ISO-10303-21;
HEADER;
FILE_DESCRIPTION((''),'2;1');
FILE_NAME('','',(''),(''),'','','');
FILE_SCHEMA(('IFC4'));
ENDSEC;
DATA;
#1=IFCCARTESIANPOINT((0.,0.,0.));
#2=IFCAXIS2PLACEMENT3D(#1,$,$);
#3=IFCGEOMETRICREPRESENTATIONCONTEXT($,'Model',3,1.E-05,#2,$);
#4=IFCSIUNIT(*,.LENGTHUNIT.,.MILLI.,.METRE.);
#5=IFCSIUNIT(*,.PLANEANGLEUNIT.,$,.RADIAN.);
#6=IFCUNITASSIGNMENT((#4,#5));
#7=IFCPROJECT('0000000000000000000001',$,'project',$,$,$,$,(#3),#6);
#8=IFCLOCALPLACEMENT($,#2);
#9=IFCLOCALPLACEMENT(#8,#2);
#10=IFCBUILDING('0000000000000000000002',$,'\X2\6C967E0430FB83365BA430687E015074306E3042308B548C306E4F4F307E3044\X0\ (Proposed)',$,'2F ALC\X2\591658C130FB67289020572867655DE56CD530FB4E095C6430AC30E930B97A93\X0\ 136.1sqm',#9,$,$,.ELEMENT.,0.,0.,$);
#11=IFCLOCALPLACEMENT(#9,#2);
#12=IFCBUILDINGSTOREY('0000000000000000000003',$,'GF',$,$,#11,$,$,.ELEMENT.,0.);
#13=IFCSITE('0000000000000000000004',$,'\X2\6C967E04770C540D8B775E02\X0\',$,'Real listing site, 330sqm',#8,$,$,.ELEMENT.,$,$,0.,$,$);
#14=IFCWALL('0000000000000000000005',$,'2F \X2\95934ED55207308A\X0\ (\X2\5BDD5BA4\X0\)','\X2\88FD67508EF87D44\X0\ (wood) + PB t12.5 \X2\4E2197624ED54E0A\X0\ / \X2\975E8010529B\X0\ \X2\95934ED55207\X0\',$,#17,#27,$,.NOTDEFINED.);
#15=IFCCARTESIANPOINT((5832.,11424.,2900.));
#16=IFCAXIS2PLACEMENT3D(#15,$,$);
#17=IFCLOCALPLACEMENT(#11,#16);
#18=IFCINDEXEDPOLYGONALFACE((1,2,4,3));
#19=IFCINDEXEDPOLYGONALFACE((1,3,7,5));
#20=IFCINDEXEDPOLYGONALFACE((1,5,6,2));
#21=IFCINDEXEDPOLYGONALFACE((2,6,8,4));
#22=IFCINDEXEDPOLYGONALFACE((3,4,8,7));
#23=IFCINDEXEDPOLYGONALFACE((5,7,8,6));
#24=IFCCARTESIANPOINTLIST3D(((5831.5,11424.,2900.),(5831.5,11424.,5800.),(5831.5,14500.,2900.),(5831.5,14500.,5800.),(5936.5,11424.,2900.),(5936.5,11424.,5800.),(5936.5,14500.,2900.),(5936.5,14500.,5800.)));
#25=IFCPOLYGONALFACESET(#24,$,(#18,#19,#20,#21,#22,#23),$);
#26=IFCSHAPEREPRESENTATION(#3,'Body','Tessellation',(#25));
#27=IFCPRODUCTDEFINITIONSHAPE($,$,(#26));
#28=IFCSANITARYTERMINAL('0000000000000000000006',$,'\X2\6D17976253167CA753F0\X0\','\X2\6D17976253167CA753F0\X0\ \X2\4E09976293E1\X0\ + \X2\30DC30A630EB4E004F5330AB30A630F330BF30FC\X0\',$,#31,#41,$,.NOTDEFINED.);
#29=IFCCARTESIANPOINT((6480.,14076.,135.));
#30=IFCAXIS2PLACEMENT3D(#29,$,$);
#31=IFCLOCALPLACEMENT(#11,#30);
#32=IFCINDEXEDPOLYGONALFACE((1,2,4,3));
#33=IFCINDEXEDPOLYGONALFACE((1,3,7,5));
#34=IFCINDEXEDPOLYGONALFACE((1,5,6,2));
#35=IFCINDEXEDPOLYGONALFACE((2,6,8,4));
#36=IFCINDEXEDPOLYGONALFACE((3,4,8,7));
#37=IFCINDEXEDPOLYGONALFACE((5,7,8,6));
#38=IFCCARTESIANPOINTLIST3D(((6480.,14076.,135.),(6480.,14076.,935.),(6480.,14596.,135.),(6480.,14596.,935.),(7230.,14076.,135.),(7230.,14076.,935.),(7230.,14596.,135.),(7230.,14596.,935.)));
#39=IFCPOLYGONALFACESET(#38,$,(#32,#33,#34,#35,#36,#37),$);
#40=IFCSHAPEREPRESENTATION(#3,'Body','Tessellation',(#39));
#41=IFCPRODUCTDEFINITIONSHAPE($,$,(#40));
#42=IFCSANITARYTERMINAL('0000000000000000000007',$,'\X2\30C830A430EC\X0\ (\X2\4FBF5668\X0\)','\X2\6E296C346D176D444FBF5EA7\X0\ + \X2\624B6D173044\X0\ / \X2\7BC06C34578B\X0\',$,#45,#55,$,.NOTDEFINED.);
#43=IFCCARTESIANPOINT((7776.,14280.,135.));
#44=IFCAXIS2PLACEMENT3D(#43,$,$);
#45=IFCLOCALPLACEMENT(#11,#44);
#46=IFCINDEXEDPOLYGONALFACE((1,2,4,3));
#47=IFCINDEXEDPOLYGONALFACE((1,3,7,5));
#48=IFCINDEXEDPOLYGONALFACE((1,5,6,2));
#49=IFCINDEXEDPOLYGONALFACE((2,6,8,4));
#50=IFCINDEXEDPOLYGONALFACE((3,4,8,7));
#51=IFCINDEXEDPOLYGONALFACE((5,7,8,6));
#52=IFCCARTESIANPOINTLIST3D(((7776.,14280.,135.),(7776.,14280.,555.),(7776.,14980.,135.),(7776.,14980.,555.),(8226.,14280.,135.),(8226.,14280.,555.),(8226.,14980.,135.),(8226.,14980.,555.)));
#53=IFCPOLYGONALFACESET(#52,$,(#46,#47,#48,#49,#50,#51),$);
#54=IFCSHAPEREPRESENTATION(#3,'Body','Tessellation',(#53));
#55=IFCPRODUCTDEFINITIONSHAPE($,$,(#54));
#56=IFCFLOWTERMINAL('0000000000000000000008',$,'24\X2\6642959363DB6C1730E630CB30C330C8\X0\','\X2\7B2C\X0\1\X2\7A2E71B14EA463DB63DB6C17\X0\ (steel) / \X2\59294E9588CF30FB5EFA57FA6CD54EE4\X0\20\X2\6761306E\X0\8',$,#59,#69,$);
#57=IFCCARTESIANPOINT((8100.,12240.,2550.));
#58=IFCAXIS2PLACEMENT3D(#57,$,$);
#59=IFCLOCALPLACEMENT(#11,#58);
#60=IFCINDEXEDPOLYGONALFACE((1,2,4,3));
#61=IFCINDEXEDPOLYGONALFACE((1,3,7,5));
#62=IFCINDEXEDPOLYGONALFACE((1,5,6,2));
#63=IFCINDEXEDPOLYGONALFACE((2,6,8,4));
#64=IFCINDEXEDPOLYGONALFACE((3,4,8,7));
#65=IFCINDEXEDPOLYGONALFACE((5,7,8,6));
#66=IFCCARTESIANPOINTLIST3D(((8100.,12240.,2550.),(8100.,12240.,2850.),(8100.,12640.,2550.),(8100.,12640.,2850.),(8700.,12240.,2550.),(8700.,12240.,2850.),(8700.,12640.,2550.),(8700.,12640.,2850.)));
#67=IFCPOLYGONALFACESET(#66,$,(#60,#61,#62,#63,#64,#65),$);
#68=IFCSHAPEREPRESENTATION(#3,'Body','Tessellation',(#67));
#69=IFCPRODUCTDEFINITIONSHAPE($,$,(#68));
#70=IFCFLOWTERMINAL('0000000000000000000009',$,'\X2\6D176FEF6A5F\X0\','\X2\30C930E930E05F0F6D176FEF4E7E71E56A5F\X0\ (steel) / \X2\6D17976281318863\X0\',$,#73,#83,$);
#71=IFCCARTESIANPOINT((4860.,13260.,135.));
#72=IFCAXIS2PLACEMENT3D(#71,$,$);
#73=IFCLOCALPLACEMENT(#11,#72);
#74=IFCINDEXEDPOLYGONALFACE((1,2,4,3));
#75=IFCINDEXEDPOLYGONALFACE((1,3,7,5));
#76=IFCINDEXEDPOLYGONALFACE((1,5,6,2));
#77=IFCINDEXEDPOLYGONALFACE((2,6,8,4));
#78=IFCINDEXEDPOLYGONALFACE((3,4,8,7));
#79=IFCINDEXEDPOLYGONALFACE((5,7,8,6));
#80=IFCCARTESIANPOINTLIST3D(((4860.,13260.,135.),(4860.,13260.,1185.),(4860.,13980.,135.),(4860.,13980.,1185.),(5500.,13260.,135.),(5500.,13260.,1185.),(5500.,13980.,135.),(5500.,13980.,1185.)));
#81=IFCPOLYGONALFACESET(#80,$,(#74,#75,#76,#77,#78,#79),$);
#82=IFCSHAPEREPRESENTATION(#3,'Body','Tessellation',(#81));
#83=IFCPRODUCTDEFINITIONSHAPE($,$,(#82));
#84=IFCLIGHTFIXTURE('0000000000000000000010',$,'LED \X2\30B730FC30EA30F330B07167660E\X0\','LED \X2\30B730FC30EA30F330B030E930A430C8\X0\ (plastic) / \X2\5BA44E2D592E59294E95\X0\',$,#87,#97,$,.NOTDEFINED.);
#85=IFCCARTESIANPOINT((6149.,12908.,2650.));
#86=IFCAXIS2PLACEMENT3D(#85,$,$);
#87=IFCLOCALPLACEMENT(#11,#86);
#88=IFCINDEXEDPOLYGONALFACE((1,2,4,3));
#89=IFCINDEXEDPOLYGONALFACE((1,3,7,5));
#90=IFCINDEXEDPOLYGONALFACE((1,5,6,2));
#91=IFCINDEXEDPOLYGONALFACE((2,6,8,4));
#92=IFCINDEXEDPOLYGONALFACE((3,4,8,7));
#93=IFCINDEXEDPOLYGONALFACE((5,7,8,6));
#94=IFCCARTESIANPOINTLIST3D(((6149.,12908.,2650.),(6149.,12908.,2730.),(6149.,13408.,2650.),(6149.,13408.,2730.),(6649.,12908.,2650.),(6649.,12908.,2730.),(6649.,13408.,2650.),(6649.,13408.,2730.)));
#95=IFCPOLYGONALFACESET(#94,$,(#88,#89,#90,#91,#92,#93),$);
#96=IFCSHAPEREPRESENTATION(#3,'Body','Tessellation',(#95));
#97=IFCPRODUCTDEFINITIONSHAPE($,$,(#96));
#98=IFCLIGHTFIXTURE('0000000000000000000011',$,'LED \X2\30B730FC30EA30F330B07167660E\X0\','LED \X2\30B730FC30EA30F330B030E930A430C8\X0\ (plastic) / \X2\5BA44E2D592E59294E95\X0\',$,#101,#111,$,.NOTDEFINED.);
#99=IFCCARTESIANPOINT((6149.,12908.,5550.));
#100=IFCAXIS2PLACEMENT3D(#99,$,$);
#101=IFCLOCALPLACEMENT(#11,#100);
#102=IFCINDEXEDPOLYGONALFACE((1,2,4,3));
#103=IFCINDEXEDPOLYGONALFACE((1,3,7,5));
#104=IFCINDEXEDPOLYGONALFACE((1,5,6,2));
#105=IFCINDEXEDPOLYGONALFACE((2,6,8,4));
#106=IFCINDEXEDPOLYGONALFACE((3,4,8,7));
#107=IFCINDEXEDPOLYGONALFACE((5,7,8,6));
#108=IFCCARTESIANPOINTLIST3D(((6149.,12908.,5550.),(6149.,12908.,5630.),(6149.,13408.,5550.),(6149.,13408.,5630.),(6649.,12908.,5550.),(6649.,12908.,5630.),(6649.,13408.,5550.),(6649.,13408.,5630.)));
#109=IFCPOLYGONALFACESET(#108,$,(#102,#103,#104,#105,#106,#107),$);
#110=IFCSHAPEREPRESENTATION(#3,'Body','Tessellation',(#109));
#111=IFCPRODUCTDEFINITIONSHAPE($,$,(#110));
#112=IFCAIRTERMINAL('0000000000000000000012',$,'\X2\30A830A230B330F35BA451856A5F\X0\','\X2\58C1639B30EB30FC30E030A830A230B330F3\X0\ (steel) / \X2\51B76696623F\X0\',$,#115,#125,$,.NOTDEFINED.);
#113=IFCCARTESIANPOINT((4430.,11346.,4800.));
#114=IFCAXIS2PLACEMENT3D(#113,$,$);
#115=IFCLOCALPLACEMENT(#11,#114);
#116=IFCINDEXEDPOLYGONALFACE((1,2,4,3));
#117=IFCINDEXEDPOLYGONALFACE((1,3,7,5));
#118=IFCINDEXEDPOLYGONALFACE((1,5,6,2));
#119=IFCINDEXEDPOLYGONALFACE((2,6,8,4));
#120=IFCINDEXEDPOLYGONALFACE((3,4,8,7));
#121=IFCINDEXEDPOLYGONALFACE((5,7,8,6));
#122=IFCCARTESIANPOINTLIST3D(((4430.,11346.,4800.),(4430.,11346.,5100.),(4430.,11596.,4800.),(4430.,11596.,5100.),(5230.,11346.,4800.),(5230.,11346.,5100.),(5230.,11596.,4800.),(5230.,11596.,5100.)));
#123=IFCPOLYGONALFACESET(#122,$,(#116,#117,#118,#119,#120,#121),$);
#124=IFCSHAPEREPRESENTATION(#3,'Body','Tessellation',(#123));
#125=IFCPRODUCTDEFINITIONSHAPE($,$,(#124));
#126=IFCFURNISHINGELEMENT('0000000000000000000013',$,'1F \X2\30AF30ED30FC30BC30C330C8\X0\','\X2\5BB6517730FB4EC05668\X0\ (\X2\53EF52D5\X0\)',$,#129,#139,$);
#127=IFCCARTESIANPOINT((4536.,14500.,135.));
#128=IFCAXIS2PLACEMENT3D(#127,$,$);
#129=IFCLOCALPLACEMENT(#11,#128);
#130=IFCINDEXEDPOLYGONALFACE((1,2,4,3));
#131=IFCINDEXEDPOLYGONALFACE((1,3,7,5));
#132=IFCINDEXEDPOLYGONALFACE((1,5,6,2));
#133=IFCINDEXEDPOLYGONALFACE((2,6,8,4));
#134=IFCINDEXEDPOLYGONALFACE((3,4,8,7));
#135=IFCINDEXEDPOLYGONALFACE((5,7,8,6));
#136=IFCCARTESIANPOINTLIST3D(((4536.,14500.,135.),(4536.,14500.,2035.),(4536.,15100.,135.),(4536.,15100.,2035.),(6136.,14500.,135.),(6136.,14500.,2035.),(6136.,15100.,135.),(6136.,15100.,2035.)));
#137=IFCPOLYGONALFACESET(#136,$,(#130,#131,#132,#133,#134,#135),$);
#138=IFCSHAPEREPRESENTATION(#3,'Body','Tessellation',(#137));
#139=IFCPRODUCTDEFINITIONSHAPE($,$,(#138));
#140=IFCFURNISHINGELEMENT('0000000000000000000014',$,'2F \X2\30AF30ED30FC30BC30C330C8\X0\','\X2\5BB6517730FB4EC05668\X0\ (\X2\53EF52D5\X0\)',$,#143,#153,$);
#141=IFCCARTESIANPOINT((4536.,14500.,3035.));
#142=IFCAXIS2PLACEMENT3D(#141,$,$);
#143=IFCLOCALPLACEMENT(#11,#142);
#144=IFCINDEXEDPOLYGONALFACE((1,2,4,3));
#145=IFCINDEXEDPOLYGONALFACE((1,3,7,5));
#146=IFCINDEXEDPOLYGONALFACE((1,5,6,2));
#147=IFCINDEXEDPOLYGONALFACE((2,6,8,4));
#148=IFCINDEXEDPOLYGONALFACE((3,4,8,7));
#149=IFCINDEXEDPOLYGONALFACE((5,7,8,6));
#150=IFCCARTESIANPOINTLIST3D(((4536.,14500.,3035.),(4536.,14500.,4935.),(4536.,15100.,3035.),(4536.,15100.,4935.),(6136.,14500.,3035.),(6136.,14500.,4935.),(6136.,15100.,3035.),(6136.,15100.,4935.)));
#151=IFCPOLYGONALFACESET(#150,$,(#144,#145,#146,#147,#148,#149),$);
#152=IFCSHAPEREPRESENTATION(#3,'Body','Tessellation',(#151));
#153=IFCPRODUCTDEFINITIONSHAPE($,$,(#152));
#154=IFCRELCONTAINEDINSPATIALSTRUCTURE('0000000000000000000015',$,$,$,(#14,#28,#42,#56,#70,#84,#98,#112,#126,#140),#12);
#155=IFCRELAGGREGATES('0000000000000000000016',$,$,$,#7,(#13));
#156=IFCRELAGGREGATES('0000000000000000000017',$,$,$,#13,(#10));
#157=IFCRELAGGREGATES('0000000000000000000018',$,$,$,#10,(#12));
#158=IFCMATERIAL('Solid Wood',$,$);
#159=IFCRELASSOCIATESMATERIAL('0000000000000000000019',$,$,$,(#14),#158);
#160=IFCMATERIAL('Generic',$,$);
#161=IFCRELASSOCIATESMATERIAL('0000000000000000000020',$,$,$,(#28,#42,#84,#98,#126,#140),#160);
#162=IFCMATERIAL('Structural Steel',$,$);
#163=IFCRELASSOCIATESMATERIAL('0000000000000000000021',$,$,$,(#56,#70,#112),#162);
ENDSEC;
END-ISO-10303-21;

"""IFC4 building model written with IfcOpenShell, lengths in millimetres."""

from ifc_helpers import new_model, si_unit, frame, frame_2d, origin, place, context, project, spatial, rectangle, extrude, material, element, save


model = new_model("IFC4")

# Units and contexts
model_context = context("Model", 3, precision=1e-05, world=origin())
ifc_project = project(units=[si_unit("LENGTHUNIT", "METRE", prefix="MILLI"), si_unit("PLANEANGLEUNIT", "RADIAN")], contexts=[model_context])

# Site, building, storey
site_placement = place(None, origin())
site = spatial("IfcSite", under=ifc_project, at=site_placement, Name="沖縄県名護市", ObjectType="Real listing site, 330sqm", CompositionType="ELEMENT", RefElevation=0.0)
building_placement = place(site_placement, origin())
building = spatial("IfcBuilding", under=site, at=building_placement, Name="沖縄・茶室と縁側のある和の住まい (Proposed)", ObjectType="2F ALC外壁・木造在来工法・三層ガラス窓 136.1sqm", CompositionType="ELEMENT", ElevationOfRefHeight=0.0, ElevationOfTerrain=0.0)
storey_placement = place(building_placement, origin())
storey = spatial("IfcBuildingStorey", under=building, at=storey_placement, Name="GF", CompositionType="ELEMENT", Elevation=0.0)

# Shared definitions
ifc_material_1 = material(Name="Solid Wood")

# Wall
wall_1_placement = place(storey_placement, frame((5832.0, 11424.0, 2900.0)))
element("IfcWall", 1, at=wall_1_placement, inside=storey, material=ifc_material_1, Name="2F 間仕切り (寝室)", Description="製材軸組 (wood) + PB t12.5 両面仕上 / 非耐力 間仕切", PredefinedType="NOTDEFINED", context=model_context, shape_type="SweptSolid", body=[
    extrude(rectangle(XDim=105.0, YDim=3076.0, at=frame_2d((52.0, 1538.0))), frame((5832.0, 11424.0, 2900.0)), (0.0, 0.0, 1.0), 2900.0),
])

# Sanitary terminals
ifc_material_2 = material(Name="Generic")
sanitary_terminal_1_placement = place(storey_placement, frame((6480.0, 14076.0, 135.0)))
element("IfcSanitaryTerminal", 2, at=sanitary_terminal_1_placement, inside=storey, material=ifc_material_2, Name="洗面化粧台", Description="洗面化粧台 三面鏡 + ボウル一体カウンター", PredefinedType="NOTDEFINED", context=model_context, shape_type="SweptSolid", body=[
    extrude(rectangle(XDim=750.0, YDim=520.0, at=frame_2d((375.0, 260.0))), frame((6480.0, 14076.0, 135.0)), (0.0, 0.0, 1.0), 800.0),
])
sanitary_terminal_2_placement = place(storey_placement, frame((7776.0, 14280.0, 135.0)))
element("IfcSanitaryTerminal", 3, at=sanitary_terminal_2_placement, inside=storey, material=ifc_material_2, Name="トイレ (便器)", Description="温水洗浄便座 + 手洗い / 節水型", PredefinedType="NOTDEFINED", context=model_context, shape_type="SweptSolid", body=[
    extrude(rectangle(XDim=450.0, YDim=700.0, at=frame_2d((225.0, 350.0))), frame((7776.0, 14280.0, 135.0)), (0.0, 0.0, 1.0), 420.0),
])

# Flow terminals
ifc_material_3 = material(Name="Structural Steel")
flow_terminal_1_placement = place(storey_placement, frame((8100.0, 12240.0, 2550.0)))
element("IfcFlowTerminal", 4, at=flow_terminal_1_placement, inside=storey, material=ifc_material_3, Name="24時間換気ユニット", Description="第1種熱交換換気 (steel) / 天井裏・建基法令20条の8", context=model_context, shape_type="SweptSolid", body=[
    extrude(rectangle(XDim=600.0, YDim=400.0, at=frame_2d((300.0, 200.0))), frame((8100.0, 12240.0, 2550.0)), (0.0, 0.0, 1.0), 300.0),
])
flow_terminal_2_placement = place(storey_placement, frame((4860.0, 13260.0, 135.0)))
element("IfcFlowTerminal", 5, at=flow_terminal_2_placement, inside=storey, material=ifc_material_3, Name="洗濯機", Description="ドラム式洗濯乾燥機 (steel) / 洗面脱衣", context=model_context, shape_type="SweptSolid", body=[
    extrude(rectangle(XDim=640.0, YDim=720.0, at=frame_2d((320.0, 360.0))), frame((4860.0, 13260.0, 135.0)), (0.0, 0.0, 1.0), 1050.0),
])

# Light fixtures
light_fixture_1_placement = place(storey_placement, frame((6149.0, 12908.0, 2650.0)))
element("IfcLightFixture", 6, at=light_fixture_1_placement, inside=storey, material=ifc_material_2, Name="LED シーリング照明", Description="LED シーリングライト (plastic) / 室中央天井", PredefinedType="NOTDEFINED", context=model_context, shape_type="SweptSolid", body=[
    extrude(rectangle(XDim=500.0, YDim=500.0, at=frame_2d((250.0, 250.0))), frame((6149.0, 12908.0, 2650.0)), (0.0, 0.0, 1.0), 80.0),
])
light_fixture_2_placement = place(storey_placement, frame((6149.0, 12908.0, 5550.0)))
element("IfcLightFixture", 7, at=light_fixture_2_placement, inside=storey, material=ifc_material_2, Name="LED シーリング照明", Description="LED シーリングライト (plastic) / 室中央天井", PredefinedType="NOTDEFINED", context=model_context, shape_type="SweptSolid", body=[
    extrude(rectangle(XDim=500.0, YDim=500.0, at=frame_2d((250.0, 250.0))), frame((6149.0, 12908.0, 5550.0)), (0.0, 0.0, 1.0), 80.0),
])

# Air terminal
air_terminal_placement = place(storey_placement, frame((4430.0, 11346.0, 4800.0)))
element("IfcAirTerminal", 8, at=air_terminal_placement, inside=storey, material=ifc_material_3, Name="エアコン室内機", Description="壁掛ルームエアコン (steel) / 冷暖房", PredefinedType="NOTDEFINED", context=model_context, shape_type="SweptSolid", body=[
    extrude(rectangle(XDim=800.0, YDim=250.0, at=frame_2d((400.0, 125.0))), frame((4430.0, 11346.0, 4800.0)), (0.0, 0.0, 1.0), 300.0),
])

# Furnishing elements
furnishing_1_placement = place(storey_placement, frame((4536.0, 14500.0, 135.0)))
element("IfcFurnishingElement", 9, at=furnishing_1_placement, inside=storey, material=ifc_material_2, Name="1F クローゼット", Description="家具・什器 (可動)", context=model_context, shape_type="SweptSolid", body=[
    extrude(rectangle(XDim=1600.0, YDim=600.0, at=frame_2d((800.0, 300.0))), frame((4536.0, 14500.0, 135.0)), (0.0, 0.0, 1.0), 1900.0),
])
furnishing_2_placement = place(storey_placement, frame((4536.0, 14500.0, 3035.0)))
element("IfcFurnishingElement", 10, at=furnishing_2_placement, inside=storey, material=ifc_material_2, Name="2F クローゼット", Description="家具・什器 (可動)", context=model_context, shape_type="SweptSolid", body=[
    extrude(rectangle(XDim=1600.0, YDim=600.0, at=frame_2d((800.0, 300.0))), frame((4536.0, 14500.0, 3035.0)), (0.0, 0.0, 1.0), 1900.0),
])

save(model, "model.ifc")
